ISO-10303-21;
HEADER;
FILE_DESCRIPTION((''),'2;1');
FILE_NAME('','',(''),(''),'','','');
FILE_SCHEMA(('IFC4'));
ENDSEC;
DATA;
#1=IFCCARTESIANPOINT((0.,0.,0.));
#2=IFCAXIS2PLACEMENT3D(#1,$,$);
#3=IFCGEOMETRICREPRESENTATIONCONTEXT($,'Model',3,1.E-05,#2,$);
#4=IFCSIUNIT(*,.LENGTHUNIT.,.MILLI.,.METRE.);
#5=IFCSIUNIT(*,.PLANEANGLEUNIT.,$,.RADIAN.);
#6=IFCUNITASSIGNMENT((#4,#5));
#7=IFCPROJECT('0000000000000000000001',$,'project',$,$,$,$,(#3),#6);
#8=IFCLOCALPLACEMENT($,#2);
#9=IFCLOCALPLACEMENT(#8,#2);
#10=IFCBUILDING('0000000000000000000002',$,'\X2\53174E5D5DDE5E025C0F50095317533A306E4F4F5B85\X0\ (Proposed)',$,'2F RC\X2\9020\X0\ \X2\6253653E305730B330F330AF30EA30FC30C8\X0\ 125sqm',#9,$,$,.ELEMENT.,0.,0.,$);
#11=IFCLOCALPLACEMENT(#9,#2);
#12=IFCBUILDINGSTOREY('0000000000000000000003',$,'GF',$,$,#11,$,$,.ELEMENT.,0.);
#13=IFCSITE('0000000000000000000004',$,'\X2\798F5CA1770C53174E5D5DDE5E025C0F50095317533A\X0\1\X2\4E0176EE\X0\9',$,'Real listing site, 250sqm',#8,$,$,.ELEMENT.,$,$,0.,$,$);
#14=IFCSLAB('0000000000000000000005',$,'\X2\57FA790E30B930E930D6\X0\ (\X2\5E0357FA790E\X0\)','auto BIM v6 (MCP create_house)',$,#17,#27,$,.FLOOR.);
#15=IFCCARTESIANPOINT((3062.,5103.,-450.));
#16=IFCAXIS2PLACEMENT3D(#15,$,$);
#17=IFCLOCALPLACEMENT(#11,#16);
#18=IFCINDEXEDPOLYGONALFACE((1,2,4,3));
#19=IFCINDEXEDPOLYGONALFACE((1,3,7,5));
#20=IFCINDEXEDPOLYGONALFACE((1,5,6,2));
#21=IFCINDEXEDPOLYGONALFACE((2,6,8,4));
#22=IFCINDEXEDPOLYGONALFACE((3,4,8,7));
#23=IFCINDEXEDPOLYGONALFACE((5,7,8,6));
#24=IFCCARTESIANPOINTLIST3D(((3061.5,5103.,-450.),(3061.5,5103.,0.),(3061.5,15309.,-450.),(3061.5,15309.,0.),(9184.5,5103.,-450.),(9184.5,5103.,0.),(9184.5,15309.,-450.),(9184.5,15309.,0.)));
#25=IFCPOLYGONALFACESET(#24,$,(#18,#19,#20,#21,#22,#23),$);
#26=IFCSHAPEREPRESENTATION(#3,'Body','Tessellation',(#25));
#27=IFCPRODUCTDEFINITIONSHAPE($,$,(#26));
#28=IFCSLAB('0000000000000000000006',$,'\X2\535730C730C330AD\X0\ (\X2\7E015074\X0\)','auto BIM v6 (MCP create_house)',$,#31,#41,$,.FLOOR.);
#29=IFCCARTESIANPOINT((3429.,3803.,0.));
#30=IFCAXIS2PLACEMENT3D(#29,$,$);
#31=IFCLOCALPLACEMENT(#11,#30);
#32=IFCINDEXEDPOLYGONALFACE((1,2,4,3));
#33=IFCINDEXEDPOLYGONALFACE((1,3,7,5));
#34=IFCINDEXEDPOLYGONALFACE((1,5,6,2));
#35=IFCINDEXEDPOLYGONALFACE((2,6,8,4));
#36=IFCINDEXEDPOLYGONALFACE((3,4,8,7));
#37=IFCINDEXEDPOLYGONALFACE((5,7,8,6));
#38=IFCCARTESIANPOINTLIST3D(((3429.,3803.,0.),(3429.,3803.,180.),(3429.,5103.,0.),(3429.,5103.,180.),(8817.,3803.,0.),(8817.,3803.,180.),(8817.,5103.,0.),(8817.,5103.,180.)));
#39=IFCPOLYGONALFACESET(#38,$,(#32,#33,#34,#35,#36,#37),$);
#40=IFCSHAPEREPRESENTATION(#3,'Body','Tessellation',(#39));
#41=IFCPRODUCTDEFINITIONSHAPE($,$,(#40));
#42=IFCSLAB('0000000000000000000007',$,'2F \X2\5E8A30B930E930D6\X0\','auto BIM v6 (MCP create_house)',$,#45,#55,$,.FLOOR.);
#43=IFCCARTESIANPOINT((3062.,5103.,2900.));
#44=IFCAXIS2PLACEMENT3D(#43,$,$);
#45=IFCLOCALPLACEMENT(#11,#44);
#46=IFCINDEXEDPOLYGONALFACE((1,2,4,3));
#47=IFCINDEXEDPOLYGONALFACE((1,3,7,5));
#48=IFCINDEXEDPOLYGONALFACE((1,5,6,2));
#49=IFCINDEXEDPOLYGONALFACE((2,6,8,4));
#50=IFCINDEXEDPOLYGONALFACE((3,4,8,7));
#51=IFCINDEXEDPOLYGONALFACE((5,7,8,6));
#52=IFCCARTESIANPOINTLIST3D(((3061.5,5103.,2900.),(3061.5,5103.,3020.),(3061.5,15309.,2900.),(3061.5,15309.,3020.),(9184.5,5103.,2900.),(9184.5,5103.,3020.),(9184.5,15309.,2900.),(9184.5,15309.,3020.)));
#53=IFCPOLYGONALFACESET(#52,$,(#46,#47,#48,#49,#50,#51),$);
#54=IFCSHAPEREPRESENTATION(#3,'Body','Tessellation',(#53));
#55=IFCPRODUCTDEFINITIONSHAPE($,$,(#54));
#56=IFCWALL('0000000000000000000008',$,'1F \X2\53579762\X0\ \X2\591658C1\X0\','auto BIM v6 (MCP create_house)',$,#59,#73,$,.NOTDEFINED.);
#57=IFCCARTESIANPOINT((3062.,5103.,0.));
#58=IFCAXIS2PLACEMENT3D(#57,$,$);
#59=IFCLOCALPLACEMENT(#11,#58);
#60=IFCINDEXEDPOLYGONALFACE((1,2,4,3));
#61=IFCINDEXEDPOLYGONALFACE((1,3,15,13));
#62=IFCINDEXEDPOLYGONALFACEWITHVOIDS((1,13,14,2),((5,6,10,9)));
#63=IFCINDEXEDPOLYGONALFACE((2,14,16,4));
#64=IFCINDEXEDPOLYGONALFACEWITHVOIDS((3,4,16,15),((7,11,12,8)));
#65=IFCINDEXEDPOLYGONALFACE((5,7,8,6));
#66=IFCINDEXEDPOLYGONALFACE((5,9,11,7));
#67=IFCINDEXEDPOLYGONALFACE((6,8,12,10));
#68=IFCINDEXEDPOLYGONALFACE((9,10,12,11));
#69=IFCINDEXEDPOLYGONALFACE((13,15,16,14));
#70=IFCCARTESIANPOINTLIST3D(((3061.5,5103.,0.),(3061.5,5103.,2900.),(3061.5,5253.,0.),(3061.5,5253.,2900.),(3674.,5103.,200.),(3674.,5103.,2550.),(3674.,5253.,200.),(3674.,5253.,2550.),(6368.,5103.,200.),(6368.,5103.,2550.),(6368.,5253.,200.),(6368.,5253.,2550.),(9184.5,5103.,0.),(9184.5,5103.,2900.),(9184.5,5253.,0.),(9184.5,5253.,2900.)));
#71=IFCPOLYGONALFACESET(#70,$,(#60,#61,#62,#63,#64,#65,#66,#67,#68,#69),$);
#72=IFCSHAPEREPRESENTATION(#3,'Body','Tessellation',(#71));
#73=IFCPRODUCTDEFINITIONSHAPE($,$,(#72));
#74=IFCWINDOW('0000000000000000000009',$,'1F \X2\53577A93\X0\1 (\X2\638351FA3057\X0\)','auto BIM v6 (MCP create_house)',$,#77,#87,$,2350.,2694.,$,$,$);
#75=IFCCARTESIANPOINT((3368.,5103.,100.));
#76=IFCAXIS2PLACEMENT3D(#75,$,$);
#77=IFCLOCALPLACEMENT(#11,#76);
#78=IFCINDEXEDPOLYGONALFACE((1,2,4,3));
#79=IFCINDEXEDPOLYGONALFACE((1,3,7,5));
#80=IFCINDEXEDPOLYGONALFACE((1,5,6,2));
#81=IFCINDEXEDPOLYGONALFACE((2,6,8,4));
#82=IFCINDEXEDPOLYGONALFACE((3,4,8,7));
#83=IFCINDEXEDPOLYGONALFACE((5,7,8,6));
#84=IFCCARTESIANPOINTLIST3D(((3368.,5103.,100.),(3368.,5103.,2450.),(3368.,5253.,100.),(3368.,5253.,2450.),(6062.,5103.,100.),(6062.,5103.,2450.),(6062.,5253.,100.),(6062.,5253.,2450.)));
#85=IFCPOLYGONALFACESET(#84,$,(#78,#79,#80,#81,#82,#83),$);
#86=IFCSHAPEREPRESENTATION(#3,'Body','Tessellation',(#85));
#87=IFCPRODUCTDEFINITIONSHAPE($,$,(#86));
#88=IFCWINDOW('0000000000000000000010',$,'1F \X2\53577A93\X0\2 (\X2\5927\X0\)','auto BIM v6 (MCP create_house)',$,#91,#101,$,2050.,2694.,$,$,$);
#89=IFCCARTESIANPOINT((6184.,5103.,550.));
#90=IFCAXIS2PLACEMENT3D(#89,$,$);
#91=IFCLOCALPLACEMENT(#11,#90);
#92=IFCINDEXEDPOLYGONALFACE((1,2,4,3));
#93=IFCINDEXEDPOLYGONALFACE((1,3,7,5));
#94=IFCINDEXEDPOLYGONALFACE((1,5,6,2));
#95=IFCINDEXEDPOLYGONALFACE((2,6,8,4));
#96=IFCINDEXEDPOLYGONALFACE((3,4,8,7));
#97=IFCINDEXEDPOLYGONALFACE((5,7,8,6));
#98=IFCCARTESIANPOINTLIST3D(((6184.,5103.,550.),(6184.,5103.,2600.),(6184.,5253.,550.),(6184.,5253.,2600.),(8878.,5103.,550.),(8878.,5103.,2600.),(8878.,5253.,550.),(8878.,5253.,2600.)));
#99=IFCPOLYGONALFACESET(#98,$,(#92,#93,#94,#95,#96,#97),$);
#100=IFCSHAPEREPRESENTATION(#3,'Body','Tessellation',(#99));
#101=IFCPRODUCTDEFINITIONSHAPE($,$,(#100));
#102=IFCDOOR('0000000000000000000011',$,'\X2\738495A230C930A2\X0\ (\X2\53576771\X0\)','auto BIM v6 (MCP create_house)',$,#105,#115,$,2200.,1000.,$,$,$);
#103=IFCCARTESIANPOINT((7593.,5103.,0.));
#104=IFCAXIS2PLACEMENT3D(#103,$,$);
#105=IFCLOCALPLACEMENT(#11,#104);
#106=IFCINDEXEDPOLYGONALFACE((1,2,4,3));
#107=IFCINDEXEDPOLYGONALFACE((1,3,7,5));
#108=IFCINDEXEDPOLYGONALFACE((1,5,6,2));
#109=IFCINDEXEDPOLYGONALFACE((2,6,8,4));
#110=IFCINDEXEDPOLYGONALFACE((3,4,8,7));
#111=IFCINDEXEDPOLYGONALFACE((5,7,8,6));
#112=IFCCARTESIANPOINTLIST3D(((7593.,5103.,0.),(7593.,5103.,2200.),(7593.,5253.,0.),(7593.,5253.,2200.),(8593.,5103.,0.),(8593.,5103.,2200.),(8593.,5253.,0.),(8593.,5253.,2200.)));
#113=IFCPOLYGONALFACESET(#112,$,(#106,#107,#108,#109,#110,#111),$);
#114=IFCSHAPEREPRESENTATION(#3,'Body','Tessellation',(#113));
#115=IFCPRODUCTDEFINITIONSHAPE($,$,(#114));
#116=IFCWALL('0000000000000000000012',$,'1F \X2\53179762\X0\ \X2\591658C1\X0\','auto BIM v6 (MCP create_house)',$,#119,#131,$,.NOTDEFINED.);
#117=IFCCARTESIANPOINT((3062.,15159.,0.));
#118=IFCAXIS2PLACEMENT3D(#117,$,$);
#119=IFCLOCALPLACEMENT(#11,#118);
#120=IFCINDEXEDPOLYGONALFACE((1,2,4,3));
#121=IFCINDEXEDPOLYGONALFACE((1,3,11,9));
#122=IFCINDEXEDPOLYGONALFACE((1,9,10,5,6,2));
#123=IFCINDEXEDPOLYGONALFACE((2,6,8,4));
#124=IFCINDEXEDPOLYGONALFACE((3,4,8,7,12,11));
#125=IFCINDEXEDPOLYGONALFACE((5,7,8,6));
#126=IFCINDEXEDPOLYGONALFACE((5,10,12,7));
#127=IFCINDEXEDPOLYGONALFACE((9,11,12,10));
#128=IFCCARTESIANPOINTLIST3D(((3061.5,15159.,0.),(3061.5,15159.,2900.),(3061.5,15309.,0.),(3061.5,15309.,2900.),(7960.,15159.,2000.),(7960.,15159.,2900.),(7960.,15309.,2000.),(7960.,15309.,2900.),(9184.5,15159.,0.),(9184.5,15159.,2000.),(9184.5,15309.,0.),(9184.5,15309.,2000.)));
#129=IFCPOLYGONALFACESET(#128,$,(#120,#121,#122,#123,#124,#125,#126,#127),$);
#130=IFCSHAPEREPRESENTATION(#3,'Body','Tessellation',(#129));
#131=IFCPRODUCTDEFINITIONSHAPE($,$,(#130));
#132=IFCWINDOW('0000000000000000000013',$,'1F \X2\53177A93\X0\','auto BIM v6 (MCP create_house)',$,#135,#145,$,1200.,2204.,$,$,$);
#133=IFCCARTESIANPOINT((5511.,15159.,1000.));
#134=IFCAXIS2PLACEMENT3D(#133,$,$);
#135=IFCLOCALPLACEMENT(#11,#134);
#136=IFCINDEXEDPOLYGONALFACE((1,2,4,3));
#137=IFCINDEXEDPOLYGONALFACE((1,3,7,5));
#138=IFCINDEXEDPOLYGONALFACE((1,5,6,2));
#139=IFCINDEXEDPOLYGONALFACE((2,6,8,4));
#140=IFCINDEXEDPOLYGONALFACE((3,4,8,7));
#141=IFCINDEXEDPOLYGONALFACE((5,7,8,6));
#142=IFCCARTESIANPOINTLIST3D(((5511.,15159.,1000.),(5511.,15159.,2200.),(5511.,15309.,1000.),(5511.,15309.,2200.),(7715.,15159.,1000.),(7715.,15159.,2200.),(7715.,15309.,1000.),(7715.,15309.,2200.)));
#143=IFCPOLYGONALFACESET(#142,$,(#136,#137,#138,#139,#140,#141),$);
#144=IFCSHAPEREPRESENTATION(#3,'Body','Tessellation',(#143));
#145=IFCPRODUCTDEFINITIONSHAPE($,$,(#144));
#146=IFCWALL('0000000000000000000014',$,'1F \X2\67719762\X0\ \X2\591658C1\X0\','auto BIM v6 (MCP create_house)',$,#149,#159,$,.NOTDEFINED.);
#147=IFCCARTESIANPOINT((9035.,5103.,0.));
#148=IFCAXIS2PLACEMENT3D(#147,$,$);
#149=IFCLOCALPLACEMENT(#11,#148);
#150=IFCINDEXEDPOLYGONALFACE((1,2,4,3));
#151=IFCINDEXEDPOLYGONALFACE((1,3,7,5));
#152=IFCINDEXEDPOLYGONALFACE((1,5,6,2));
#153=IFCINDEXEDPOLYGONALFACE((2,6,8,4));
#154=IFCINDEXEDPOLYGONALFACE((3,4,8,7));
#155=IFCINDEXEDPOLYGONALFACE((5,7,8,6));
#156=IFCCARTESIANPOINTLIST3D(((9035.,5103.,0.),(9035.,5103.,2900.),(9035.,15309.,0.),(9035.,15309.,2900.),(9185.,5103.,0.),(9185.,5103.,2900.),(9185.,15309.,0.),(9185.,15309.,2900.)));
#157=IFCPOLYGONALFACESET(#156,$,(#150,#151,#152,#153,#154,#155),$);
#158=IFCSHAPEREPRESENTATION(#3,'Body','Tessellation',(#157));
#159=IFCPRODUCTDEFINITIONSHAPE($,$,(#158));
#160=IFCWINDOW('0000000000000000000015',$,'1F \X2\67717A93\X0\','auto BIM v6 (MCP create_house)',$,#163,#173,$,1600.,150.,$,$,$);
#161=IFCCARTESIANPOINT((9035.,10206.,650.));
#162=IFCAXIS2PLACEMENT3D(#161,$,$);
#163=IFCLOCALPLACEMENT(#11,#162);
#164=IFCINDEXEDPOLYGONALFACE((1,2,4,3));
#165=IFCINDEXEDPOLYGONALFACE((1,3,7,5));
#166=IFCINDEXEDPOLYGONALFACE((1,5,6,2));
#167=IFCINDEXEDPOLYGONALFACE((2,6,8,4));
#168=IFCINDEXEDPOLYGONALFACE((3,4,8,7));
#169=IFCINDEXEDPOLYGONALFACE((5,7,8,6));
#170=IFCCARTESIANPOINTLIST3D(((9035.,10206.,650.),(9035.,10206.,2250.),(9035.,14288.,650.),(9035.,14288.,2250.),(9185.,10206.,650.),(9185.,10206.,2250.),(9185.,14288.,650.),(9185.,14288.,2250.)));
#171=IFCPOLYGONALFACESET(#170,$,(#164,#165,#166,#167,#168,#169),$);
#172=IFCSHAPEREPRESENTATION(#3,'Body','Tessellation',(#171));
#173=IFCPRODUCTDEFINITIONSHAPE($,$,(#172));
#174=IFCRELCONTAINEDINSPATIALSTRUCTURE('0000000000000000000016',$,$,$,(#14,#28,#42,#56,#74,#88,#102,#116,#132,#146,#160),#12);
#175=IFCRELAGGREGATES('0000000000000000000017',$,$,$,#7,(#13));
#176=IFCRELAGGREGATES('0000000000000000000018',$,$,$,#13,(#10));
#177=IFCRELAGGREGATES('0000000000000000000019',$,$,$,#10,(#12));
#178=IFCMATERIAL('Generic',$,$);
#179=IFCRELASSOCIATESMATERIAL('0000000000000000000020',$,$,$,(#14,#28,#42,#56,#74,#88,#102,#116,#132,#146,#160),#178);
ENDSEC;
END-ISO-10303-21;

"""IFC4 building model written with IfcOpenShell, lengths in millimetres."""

from ifc_helpers import new_model, si_unit, frame, frame_2d, origin, place, context, project, spatial, rectangle, extrude, material, element, fill, save


model = new_model("IFC4")

# Units and contexts
model_context = context("Model", 3, precision=1e-05, world=origin())
ifc_project = project(units=[si_unit("LENGTHUNIT", "METRE", prefix="MILLI"), si_unit("PLANEANGLEUNIT", "RADIAN")], contexts=[model_context])

# Site, building, storey
site_placement = place(None, origin())
site = spatial("IfcSite", under=ifc_project, at=site_placement, Name="福岡県北九州市小倉北区1丁目9", ObjectType="Real listing site, 250sqm", CompositionType="ELEMENT", RefElevation=0.0)
building_placement = place(site_placement, origin())
building = spatial("IfcBuilding", under=site, at=building_placement, Name="北九州市小倉北区の住宅 (Proposed)", ObjectType="2F RC造 打放しコンクリート 125sqm", CompositionType="ELEMENT", ElevationOfRefHeight=0.0, ElevationOfTerrain=0.0)
storey_placement = place(building_placement, origin())
storey = spatial("IfcBuildingStorey", under=building, at=storey_placement, Name="GF", CompositionType="ELEMENT", Elevation=0.0)

# Slabs
ifc_material = material(Name="Generic")
slab_1_placement = place(storey_placement, frame((3062.0, 5103.0, -450.0)))
element("IfcSlab", 1, at=slab_1_placement, inside=storey, material=ifc_material, Name="基礎スラブ (布基礎)", Description="auto BIM v6 (MCP create_house)", PredefinedType="FLOOR", context=model_context, shape_type="SweptSolid", body=[
    extrude(rectangle(XDim=6123.0, YDim=10206.0, at=frame_2d((3061.0, 5103.0))), frame((3062.0, 5103.0, -450.0)), (0.0, 0.0, 1.0), 450.0),
])
slab_2_placement = place(storey_placement, frame((3429.0, 3803.0, 0.0)))
element("IfcSlab", 2, at=slab_2_placement, inside=storey, material=ifc_material, Name="南デッキ (縁側)", Description="auto BIM v6 (MCP create_house)", PredefinedType="FLOOR", context=model_context, shape_type="SweptSolid", body=[
    extrude(rectangle(XDim=5388.0, YDim=1300.0, at=frame_2d((2694.0, 650.0))), frame((3429.0, 3803.0, 0.0)), (0.0, 0.0, 1.0), 180.0),
])
slab_3_placement = place(storey_placement, frame((3062.0, 5103.0, 2900.0)))
element("IfcSlab", 3, at=slab_3_placement, inside=storey, material=ifc_material, Name="2F 床スラブ", Description="auto BIM v6 (MCP create_house)", PredefinedType="FLOOR", context=model_context, shape_type="SweptSolid", body=[
    extrude(rectangle(XDim=6123.0, YDim=10206.0, at=frame_2d((3061.0, 5103.0))), frame((3062.0, 5103.0, 2900.0)), (0.0, 0.0, 1.0), 120.0),
])

# Wall, openings, windows, door
wall_1_placement = place(storey_placement, frame((3062.0, 5103.0, 0.0)))
wall_1 = element("IfcWall", 4, at=wall_1_placement, inside=storey, material=ifc_material, Name="1F 南面 外壁", Description="auto BIM v6 (MCP create_house)", PredefinedType="NOTDEFINED", context=model_context, shape_type="SweptSolid", body=[
    extrude(rectangle(XDim=6123.0, YDim=150.0, at=frame_2d((3061.0, 75.0))), frame((3062.0, 5103.0, 0.0)), (0.0, 0.0, 1.0), 2900.0),
])
opening_1_placement = place(storey_placement, frame((3368.0, 5103.0, 100.0)))
opening_1 = element("IfcOpeningElement", 5, at=opening_1_placement, cuts=wall_1, PredefinedType="NOTDEFINED", context=model_context, shape_type="SweptSolid", body=[
    extrude(rectangle(XDim=2694.0, YDim=150.0, at=frame_2d((1347.0, 75.0))), frame((3368.0, 5103.0, 100.0)), (0.0, 0.0, 1.0), 2350.0),
])
opening_2_placement = place(storey_placement, frame((6184.0, 5103.0, 550.0)))
opening_2 = element("IfcOpeningElement", 6, at=opening_2_placement, cuts=wall_1, PredefinedType="NOTDEFINED", context=model_context, shape_type="SweptSolid", body=[
    extrude(rectangle(XDim=2694.0, YDim=150.0, at=frame_2d((1347.0, 75.0))), frame((6184.0, 5103.0, 550.0)), (0.0, 0.0, 1.0), 2050.0),
])
opening_3_placement = place(storey_placement, frame((7593.0, 5103.0, 0.0)))
opening_3 = element("IfcOpeningElement", 7, at=opening_3_placement, cuts=wall_1, PredefinedType="NOTDEFINED", context=model_context, shape_type="SweptSolid", body=[
    extrude(rectangle(XDim=1000.0, YDim=150.0, at=frame_2d((500.0, 75.0))), frame((7593.0, 5103.0, 0.0)), (0.0, 0.0, 1.0), 2200.0),
])
window_1_placement = place(storey_placement, frame((3368.0, 5103.0, 100.0)))
window_1 = element("IfcWindow", 8, at=window_1_placement, inside=storey, material=ifc_material, Name="1F 南窓1 (掃出し)", Description="auto BIM v6 (MCP create_house)", OverallHeight=2350.0, OverallWidth=2694.0, context=model_context, shape_type="SweptSolid", body=[
    extrude(rectangle(XDim=2694.0, YDim=150.0, at=frame_2d((1347.0, 75.0))), frame((3368.0, 5103.0, 100.0)), (0.0, 0.0, 1.0), 2350.0),
])
fill(opening_1, window_1)
window_2_placement = place(storey_placement, frame((6184.0, 5103.0, 550.0)))
window_2 = element("IfcWindow", 9, at=window_2_placement, inside=storey, material=ifc_material, Name="1F 南窓2 (大)", Description="auto BIM v6 (MCP create_house)", OverallHeight=2050.0, OverallWidth=2694.0, context=model_context, shape_type="SweptSolid", body=[
    extrude(rectangle(XDim=2694.0, YDim=150.0, at=frame_2d((1347.0, 75.0))), frame((6184.0, 5103.0, 550.0)), (0.0, 0.0, 1.0), 2050.0),
])
fill(opening_2, window_2)
door_1_placement = place(storey_placement, frame((7593.0, 5103.0, 0.0)))
door_1 = element("IfcDoor", 10, at=door_1_placement, inside=storey, material=ifc_material, Name="玄関ドア (南東)", Description="auto BIM v6 (MCP create_house)", OverallHeight=2200.0, OverallWidth=1000.0, context=model_context, shape_type="SweptSolid", body=[
    extrude(rectangle(XDim=1000.0, YDim=150.0, at=frame_2d((500.0, 75.0))), frame((7593.0, 5103.0, 0.0)), (0.0, 0.0, 1.0), 2200.0),
])
fill(opening_3, door_1)

# Walls, openings, windows
wall_2_placement = place(storey_placement, frame((3062.0, 15159.0, 0.0)))
wall_2 = element("IfcWall", 11, at=wall_2_placement, inside=storey, material=ifc_material, Name="1F 北面 外壁", Description="auto BIM v6 (MCP create_house)", PredefinedType="NOTDEFINED", context=model_context, shape_type="SweptSolid", body=[
    extrude(rectangle(XDim=6123.0, YDim=150.0, at=frame_2d((3061.0, 75.0))), frame((3062.0, 15159.0, 0.0)), (0.0, 0.0, 1.0), 2900.0),
])
opening_4_placement = place(storey_placement, frame((5511.0, 15159.0, 1000.0)))
opening_4 = element("IfcOpeningElement", 12, at=opening_4_placement, cuts=wall_2, PredefinedType="NOTDEFINED", context=model_context, shape_type="SweptSolid", body=[
    extrude(rectangle(XDim=2204.0, YDim=150.0, at=frame_2d((1102.0, 75.0))), frame((5511.0, 15159.0, 1000.0)), (0.0, 0.0, 1.0), 1200.0),
])
window_3_placement = place(storey_placement, frame((5511.0, 15159.0, 1000.0)))
window_3 = element("IfcWindow", 13, at=window_3_placement, inside=storey, material=ifc_material, Name="1F 北窓", Description="auto BIM v6 (MCP create_house)", OverallHeight=1200.0, OverallWidth=2204.0, context=model_context, shape_type="SweptSolid", body=[
    extrude(rectangle(XDim=2204.0, YDim=150.0, at=frame_2d((1102.0, 75.0))), frame((5511.0, 15159.0, 1000.0)), (0.0, 0.0, 1.0), 1200.0),
])
fill(opening_4, window_3)
wall_3_placement = place(storey_placement, frame((9035.0, 5103.0, 0.0)))
wall_3 = element("IfcWall", 14, at=wall_3_placement, inside=storey, material=ifc_material, Name="1F 東面 外壁", Description="auto BIM v6 (MCP create_house)", PredefinedType="NOTDEFINED", context=model_context, shape_type="SweptSolid", body=[
    extrude(rectangle(XDim=150.0, YDim=10206.0, at=frame_2d((75.0, 5103.0))), frame((9035.0, 5103.0, 0.0)), (0.0, 0.0, 1.0), 2900.0),
])
opening_5_placement = place(storey_placement, frame((9035.0, 10206.0, 650.0)))
opening_5 = element("IfcOpeningElement", 15, at=opening_5_placement, cuts=wall_3, PredefinedType="NOTDEFINED", context=model_context, shape_type="SweptSolid", body=[
    extrude(rectangle(XDim=150.0, YDim=4082.0, at=frame_2d((75.0, 2041.0))), frame((9035.0, 10206.0, 650.0)), (0.0, 0.0, 1.0), 1600.0),
])
window_4_placement = place(storey_placement, frame((9035.0, 10206.0, 650.0)))
window_4 = element("IfcWindow", 16, at=window_4_placement, inside=storey, material=ifc_material, Name="1F 東窓", Description="auto BIM v6 (MCP create_house)", OverallHeight=1600.0, OverallWidth=150.0, context=model_context, shape_type="SweptSolid", body=[
    extrude(rectangle(XDim=150.0, YDim=4082.0, at=frame_2d((75.0, 2041.0))), frame((9035.0, 10206.0, 650.0)), (0.0, 0.0, 1.0), 1600.0),
])
fill(opening_5, window_4)

save(model, "model.ifc")
